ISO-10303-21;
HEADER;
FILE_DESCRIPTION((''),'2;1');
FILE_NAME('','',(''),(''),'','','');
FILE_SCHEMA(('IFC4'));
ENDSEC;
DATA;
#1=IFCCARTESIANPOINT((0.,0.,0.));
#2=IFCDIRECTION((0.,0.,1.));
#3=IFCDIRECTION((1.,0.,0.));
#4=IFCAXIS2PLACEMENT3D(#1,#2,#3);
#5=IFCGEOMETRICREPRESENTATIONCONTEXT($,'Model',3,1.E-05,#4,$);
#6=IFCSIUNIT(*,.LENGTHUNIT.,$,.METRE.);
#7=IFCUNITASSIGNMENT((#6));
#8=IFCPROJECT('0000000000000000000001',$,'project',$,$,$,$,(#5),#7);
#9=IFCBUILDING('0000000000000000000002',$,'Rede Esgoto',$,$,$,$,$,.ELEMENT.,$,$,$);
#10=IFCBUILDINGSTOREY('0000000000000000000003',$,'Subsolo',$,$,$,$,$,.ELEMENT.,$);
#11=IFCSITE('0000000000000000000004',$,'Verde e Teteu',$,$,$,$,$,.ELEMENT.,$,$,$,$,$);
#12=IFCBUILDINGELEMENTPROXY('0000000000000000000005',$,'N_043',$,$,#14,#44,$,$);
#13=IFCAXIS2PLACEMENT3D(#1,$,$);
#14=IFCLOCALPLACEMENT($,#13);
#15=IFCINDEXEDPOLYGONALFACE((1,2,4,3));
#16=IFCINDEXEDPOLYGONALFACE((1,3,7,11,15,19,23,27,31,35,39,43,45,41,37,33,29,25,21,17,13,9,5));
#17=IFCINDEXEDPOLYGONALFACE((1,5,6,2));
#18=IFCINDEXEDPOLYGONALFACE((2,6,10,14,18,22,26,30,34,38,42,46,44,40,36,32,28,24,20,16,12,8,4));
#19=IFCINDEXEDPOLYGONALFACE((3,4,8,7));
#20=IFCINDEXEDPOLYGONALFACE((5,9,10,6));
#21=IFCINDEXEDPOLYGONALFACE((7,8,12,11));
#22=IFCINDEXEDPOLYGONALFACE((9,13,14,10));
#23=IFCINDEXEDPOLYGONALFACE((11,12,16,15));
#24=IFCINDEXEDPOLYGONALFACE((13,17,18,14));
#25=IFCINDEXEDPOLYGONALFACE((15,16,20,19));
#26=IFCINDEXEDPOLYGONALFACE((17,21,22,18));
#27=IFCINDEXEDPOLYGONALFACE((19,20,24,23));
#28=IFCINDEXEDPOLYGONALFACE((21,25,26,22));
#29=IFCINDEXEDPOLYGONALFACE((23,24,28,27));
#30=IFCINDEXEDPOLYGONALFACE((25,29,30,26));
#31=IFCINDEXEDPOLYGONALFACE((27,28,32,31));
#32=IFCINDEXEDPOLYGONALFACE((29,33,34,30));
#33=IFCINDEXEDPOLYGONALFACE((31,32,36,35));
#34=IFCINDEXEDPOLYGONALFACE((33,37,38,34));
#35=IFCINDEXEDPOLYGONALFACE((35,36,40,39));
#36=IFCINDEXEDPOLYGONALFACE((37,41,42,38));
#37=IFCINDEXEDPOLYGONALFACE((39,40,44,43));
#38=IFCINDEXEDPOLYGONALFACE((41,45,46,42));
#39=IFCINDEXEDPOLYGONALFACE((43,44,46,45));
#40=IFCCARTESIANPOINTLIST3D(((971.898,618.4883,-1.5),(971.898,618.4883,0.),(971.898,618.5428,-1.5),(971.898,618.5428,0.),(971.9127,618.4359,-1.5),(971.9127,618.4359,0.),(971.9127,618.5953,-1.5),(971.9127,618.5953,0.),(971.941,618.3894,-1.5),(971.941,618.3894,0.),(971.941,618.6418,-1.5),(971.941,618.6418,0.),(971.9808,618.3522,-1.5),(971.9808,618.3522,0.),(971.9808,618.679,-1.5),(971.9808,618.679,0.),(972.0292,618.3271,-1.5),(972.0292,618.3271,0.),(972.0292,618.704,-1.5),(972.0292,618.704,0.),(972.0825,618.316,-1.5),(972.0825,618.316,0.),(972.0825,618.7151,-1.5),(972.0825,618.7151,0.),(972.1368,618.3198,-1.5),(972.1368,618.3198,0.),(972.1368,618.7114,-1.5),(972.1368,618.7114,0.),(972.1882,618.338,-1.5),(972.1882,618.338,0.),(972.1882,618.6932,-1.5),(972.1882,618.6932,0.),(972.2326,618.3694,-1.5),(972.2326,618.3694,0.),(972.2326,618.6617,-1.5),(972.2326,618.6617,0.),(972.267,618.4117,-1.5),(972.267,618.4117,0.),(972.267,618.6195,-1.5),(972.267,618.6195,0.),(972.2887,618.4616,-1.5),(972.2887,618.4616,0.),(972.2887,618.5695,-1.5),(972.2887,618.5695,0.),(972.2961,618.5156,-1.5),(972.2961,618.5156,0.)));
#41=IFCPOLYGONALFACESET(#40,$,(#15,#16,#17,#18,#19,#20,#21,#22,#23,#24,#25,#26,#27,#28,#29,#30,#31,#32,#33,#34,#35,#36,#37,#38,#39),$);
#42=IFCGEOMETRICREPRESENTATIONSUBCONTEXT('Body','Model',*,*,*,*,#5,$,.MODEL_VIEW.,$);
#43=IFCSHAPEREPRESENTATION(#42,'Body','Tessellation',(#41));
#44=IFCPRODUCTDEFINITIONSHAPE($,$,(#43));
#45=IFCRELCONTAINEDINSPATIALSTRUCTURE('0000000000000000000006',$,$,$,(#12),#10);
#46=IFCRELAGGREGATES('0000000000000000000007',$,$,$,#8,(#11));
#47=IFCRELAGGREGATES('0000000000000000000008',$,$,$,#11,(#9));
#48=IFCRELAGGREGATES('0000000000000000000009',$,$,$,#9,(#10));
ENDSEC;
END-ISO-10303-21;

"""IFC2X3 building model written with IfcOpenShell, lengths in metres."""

from ifc_helpers import new_model, si_unit, frame, origin_with_axes, origin_2d, place, context, subcontext, project, spatial, circle, extrude, element, save


model = new_model("IFC2X3")

# Units and contexts
model_context = context("Model", 3, precision=1e-05, world=origin_with_axes())
body_context = subcontext(model_context, "Body", "Model", "MODEL_VIEW")
ifc_project = project(units=[si_unit("LENGTHUNIT", "METRE")], contexts=[model_context])

# Site, building, storey
site = spatial("IfcSite", under=ifc_project, Name="Verde e Teteu", CompositionType="ELEMENT")
building = spatial("IfcBuilding", under=site, Name="Rede Esgoto", CompositionType="ELEMENT")
storey = spatial("IfcBuildingStorey", under=building, Name="Subsolo", CompositionType="ELEMENT")

# Building element proxy
for number, where, z_axis, x_axis, name in (
    (1, (972.0961, 618.5156, -1.5), (0.0, 0.0, 1.0), (1.0, 0.0, 0.0), "N_043"),
):
    element("IfcBuildingElementProxy", number, at=place(None, frame(where, z_axis=z_axis, x_axis=x_axis)), inside=storey, Name=name, context=body_context, shape_type="SweptSolid", body=[
        extrude(circle(Radius=0.2, at=origin_2d()), origin_with_axes(), (0.0, 0.0, 1.0), 1.5),
    ])

save(model, "model.ifc")
